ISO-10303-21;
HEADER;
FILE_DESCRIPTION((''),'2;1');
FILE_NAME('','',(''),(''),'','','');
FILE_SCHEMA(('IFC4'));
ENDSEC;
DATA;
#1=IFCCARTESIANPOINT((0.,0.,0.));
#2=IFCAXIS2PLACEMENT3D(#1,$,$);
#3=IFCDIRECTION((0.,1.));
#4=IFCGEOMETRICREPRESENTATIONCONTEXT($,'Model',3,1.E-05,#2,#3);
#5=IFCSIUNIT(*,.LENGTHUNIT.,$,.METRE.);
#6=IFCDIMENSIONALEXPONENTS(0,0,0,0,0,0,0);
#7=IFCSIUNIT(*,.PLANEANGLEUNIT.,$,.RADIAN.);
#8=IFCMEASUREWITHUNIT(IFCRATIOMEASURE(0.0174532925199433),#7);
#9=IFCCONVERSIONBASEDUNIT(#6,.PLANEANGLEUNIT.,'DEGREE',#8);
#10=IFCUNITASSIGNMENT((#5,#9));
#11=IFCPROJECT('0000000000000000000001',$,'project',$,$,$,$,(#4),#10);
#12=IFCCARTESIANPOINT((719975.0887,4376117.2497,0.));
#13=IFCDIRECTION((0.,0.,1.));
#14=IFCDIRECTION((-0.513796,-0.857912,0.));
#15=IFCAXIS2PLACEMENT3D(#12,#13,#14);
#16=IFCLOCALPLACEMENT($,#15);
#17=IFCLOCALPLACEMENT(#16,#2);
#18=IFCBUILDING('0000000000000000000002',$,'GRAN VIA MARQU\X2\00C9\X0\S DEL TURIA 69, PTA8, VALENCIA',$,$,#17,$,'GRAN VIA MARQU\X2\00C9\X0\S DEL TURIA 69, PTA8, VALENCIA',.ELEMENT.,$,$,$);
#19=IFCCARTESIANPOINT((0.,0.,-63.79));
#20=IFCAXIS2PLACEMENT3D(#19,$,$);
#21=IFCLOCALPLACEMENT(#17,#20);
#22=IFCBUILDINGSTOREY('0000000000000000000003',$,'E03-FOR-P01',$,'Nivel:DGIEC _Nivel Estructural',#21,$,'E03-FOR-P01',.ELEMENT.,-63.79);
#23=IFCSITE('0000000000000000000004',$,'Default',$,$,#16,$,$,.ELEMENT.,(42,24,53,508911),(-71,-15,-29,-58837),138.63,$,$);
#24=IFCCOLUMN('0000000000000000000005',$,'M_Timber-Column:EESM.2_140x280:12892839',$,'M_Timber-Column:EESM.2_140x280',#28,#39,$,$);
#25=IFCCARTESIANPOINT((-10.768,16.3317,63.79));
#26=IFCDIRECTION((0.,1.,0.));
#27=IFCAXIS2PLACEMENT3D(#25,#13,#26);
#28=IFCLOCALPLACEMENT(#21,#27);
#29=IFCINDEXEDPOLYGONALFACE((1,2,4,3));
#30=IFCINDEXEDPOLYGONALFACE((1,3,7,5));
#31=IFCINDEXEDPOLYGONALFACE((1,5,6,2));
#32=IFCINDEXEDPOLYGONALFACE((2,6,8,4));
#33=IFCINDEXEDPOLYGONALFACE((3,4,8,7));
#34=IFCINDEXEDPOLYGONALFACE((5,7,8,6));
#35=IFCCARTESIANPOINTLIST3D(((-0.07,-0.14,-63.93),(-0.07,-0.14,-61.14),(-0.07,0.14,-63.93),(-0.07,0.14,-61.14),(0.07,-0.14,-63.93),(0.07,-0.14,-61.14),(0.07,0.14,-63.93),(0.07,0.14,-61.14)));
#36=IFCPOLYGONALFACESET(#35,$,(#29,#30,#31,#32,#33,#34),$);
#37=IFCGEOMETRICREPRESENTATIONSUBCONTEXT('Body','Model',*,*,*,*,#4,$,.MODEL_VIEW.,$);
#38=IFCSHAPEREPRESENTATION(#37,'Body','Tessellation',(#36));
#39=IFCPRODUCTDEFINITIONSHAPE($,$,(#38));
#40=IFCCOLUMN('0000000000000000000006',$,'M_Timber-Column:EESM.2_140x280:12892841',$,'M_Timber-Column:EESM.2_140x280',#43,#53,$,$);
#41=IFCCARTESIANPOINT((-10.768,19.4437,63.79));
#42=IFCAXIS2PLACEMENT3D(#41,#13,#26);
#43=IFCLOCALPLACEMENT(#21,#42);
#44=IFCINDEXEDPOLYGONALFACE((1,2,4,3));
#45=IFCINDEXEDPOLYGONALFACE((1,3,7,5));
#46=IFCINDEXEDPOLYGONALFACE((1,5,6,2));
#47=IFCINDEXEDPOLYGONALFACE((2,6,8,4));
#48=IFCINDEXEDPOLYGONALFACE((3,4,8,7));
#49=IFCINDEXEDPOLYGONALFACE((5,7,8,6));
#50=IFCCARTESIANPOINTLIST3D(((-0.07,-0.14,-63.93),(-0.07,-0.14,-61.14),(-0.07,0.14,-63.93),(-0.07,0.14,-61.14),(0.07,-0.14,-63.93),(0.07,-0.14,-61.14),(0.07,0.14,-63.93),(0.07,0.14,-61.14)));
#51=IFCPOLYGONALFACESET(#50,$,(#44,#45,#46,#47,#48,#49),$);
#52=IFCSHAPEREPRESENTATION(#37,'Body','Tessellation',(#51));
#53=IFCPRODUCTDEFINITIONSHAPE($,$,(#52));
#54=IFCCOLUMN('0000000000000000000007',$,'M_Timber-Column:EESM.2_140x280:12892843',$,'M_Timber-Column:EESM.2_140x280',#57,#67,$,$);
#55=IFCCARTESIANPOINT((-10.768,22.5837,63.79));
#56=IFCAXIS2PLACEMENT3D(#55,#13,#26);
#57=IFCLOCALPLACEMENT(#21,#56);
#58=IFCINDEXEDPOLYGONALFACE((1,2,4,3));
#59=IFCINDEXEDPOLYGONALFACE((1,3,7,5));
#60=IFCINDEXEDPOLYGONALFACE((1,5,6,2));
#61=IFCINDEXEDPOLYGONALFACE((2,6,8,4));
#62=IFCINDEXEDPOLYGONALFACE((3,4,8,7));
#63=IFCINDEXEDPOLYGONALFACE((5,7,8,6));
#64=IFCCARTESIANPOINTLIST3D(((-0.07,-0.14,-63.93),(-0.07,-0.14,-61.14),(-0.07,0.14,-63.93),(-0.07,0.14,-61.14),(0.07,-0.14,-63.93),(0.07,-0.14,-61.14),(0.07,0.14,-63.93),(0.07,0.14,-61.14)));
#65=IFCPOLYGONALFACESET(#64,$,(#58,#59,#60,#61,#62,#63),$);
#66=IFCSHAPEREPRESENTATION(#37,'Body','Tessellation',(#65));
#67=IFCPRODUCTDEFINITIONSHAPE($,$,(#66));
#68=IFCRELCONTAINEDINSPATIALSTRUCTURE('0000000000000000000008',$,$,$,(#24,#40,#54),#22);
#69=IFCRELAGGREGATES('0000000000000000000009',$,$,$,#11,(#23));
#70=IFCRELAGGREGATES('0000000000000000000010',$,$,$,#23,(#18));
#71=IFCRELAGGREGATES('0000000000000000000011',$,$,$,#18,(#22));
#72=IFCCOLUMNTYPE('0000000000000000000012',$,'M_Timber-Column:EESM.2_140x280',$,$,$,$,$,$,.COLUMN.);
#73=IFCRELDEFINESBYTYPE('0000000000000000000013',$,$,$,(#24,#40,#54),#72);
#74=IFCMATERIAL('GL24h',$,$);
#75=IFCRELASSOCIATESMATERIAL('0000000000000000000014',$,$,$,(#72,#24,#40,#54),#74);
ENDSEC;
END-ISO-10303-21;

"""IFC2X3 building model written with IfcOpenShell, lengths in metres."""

from ifc_helpers import new_model, entity, si_unit, converted_unit, direction, frame, origin, origin_2d_with_axis, place, context, subcontext, project, spatial, rectangle, extrude, source, transform, mapped, material, type_object, type_shapes, element, save


model = new_model("IFC2X3")

# Units and contexts
model_context = context("Model", 3, precision=1e-05, world=origin(), true_north=direction((0.0, 1.0)))
body_context = subcontext(model_context, "Body", "Model", "MODEL_VIEW")
ifc_project = project(units=[si_unit("LENGTHUNIT", "METRE"), converted_unit("PLANEANGLEUNIT", "DEGREE", entity("IfcRatioMeasure", 0.0174532925199433), si_unit("PLANEANGLEUNIT", "RADIAN"), dimensions=[0, 0, 0, 0, 0, 0, 0])], contexts=[model_context])

# Site, building, storey
site_placement = place(None, frame((719975.0887, 4376117.2497, 0.0), z_axis=(0.0, 0.0, 1.0), x_axis=(-0.513796, -0.857912, 0.0)))
site = spatial("IfcSite", under=ifc_project, at=site_placement, Name="Default", CompositionType="ELEMENT", RefLatitude=(42, 24, 53, 508911), RefLongitude=(-71, -15, -29, -58837), RefElevation=138.63)
building_placement = place(site_placement, origin())
building = spatial("IfcBuilding", under=site, at=building_placement, Name="GRAN VIA MARQUÉS DEL TURIA 69, PTA8, VALENCIA", LongName="GRAN VIA MARQUÉS DEL TURIA 69, PTA8, VALENCIA", CompositionType="ELEMENT")
storey_placement = place(building_placement, frame((0.0, 0.0, -63.79)))
storey = spatial("IfcBuildingStorey", under=building, at=storey_placement, Name="E03-FOR-P01", ObjectType="Nivel:DGIEC _Nivel Estructural", LongName="E03-FOR-P01", CompositionType="ELEMENT", Elevation=-63.79)

# Columns
ifc_material_1 = material(Name="GL24h")
column_type_1 = type_object("IfcColumnType", Name="M_Timber-Column:EESM.2_140x280", PredefinedType="COLUMN", material=ifc_material_1)
shared_shape_1 = source(origin(), body_context, "Body", "SweptSolid", [
    extrude(rectangle(XDim=0.28, YDim=0.14, at=origin_2d_with_axis()), frame((0.0, 0.0, -63.93), z_axis=(0.0, 0.0, 1.0), x_axis=(0.0, -1.0, 0.0)), (0.0, 0.0, 1.0), 2.79),
])
type_shapes(column_type_1, [shared_shape_1])
for number, where, z_axis, x_axis, name in (
    (1, (-10.768, 16.3317, 63.79), (0.0, 0.0, 1.0), (0.0, 1.0, 0.0), "M_Timber-Column:EESM.2_140x280:12892839"),
    (2, (-10.768, 19.4437, 63.79), (0.0, 0.0, 1.0), (0.0, 1.0, 0.0), "M_Timber-Column:EESM.2_140x280:12892841"),
    (3, (-10.768, 22.5837, 63.79), (0.0, 0.0, 1.0), (0.0, 1.0, 0.0), "M_Timber-Column:EESM.2_140x280:12892843"),
):
    element("IfcColumn", number, at=place(storey_placement, frame(where, z_axis=z_axis, x_axis=x_axis)), inside=storey, type_object=column_type_1, material=ifc_material_1, Name=name, ObjectType="M_Timber-Column:EESM.2_140x280", context=body_context, shape_type="MappedRepresentation", body=[
        mapped(shared_shape_1, transform((0.0, 0.0, 0.0), scale=1.0)),
    ])

save(model, "model.ifc")
